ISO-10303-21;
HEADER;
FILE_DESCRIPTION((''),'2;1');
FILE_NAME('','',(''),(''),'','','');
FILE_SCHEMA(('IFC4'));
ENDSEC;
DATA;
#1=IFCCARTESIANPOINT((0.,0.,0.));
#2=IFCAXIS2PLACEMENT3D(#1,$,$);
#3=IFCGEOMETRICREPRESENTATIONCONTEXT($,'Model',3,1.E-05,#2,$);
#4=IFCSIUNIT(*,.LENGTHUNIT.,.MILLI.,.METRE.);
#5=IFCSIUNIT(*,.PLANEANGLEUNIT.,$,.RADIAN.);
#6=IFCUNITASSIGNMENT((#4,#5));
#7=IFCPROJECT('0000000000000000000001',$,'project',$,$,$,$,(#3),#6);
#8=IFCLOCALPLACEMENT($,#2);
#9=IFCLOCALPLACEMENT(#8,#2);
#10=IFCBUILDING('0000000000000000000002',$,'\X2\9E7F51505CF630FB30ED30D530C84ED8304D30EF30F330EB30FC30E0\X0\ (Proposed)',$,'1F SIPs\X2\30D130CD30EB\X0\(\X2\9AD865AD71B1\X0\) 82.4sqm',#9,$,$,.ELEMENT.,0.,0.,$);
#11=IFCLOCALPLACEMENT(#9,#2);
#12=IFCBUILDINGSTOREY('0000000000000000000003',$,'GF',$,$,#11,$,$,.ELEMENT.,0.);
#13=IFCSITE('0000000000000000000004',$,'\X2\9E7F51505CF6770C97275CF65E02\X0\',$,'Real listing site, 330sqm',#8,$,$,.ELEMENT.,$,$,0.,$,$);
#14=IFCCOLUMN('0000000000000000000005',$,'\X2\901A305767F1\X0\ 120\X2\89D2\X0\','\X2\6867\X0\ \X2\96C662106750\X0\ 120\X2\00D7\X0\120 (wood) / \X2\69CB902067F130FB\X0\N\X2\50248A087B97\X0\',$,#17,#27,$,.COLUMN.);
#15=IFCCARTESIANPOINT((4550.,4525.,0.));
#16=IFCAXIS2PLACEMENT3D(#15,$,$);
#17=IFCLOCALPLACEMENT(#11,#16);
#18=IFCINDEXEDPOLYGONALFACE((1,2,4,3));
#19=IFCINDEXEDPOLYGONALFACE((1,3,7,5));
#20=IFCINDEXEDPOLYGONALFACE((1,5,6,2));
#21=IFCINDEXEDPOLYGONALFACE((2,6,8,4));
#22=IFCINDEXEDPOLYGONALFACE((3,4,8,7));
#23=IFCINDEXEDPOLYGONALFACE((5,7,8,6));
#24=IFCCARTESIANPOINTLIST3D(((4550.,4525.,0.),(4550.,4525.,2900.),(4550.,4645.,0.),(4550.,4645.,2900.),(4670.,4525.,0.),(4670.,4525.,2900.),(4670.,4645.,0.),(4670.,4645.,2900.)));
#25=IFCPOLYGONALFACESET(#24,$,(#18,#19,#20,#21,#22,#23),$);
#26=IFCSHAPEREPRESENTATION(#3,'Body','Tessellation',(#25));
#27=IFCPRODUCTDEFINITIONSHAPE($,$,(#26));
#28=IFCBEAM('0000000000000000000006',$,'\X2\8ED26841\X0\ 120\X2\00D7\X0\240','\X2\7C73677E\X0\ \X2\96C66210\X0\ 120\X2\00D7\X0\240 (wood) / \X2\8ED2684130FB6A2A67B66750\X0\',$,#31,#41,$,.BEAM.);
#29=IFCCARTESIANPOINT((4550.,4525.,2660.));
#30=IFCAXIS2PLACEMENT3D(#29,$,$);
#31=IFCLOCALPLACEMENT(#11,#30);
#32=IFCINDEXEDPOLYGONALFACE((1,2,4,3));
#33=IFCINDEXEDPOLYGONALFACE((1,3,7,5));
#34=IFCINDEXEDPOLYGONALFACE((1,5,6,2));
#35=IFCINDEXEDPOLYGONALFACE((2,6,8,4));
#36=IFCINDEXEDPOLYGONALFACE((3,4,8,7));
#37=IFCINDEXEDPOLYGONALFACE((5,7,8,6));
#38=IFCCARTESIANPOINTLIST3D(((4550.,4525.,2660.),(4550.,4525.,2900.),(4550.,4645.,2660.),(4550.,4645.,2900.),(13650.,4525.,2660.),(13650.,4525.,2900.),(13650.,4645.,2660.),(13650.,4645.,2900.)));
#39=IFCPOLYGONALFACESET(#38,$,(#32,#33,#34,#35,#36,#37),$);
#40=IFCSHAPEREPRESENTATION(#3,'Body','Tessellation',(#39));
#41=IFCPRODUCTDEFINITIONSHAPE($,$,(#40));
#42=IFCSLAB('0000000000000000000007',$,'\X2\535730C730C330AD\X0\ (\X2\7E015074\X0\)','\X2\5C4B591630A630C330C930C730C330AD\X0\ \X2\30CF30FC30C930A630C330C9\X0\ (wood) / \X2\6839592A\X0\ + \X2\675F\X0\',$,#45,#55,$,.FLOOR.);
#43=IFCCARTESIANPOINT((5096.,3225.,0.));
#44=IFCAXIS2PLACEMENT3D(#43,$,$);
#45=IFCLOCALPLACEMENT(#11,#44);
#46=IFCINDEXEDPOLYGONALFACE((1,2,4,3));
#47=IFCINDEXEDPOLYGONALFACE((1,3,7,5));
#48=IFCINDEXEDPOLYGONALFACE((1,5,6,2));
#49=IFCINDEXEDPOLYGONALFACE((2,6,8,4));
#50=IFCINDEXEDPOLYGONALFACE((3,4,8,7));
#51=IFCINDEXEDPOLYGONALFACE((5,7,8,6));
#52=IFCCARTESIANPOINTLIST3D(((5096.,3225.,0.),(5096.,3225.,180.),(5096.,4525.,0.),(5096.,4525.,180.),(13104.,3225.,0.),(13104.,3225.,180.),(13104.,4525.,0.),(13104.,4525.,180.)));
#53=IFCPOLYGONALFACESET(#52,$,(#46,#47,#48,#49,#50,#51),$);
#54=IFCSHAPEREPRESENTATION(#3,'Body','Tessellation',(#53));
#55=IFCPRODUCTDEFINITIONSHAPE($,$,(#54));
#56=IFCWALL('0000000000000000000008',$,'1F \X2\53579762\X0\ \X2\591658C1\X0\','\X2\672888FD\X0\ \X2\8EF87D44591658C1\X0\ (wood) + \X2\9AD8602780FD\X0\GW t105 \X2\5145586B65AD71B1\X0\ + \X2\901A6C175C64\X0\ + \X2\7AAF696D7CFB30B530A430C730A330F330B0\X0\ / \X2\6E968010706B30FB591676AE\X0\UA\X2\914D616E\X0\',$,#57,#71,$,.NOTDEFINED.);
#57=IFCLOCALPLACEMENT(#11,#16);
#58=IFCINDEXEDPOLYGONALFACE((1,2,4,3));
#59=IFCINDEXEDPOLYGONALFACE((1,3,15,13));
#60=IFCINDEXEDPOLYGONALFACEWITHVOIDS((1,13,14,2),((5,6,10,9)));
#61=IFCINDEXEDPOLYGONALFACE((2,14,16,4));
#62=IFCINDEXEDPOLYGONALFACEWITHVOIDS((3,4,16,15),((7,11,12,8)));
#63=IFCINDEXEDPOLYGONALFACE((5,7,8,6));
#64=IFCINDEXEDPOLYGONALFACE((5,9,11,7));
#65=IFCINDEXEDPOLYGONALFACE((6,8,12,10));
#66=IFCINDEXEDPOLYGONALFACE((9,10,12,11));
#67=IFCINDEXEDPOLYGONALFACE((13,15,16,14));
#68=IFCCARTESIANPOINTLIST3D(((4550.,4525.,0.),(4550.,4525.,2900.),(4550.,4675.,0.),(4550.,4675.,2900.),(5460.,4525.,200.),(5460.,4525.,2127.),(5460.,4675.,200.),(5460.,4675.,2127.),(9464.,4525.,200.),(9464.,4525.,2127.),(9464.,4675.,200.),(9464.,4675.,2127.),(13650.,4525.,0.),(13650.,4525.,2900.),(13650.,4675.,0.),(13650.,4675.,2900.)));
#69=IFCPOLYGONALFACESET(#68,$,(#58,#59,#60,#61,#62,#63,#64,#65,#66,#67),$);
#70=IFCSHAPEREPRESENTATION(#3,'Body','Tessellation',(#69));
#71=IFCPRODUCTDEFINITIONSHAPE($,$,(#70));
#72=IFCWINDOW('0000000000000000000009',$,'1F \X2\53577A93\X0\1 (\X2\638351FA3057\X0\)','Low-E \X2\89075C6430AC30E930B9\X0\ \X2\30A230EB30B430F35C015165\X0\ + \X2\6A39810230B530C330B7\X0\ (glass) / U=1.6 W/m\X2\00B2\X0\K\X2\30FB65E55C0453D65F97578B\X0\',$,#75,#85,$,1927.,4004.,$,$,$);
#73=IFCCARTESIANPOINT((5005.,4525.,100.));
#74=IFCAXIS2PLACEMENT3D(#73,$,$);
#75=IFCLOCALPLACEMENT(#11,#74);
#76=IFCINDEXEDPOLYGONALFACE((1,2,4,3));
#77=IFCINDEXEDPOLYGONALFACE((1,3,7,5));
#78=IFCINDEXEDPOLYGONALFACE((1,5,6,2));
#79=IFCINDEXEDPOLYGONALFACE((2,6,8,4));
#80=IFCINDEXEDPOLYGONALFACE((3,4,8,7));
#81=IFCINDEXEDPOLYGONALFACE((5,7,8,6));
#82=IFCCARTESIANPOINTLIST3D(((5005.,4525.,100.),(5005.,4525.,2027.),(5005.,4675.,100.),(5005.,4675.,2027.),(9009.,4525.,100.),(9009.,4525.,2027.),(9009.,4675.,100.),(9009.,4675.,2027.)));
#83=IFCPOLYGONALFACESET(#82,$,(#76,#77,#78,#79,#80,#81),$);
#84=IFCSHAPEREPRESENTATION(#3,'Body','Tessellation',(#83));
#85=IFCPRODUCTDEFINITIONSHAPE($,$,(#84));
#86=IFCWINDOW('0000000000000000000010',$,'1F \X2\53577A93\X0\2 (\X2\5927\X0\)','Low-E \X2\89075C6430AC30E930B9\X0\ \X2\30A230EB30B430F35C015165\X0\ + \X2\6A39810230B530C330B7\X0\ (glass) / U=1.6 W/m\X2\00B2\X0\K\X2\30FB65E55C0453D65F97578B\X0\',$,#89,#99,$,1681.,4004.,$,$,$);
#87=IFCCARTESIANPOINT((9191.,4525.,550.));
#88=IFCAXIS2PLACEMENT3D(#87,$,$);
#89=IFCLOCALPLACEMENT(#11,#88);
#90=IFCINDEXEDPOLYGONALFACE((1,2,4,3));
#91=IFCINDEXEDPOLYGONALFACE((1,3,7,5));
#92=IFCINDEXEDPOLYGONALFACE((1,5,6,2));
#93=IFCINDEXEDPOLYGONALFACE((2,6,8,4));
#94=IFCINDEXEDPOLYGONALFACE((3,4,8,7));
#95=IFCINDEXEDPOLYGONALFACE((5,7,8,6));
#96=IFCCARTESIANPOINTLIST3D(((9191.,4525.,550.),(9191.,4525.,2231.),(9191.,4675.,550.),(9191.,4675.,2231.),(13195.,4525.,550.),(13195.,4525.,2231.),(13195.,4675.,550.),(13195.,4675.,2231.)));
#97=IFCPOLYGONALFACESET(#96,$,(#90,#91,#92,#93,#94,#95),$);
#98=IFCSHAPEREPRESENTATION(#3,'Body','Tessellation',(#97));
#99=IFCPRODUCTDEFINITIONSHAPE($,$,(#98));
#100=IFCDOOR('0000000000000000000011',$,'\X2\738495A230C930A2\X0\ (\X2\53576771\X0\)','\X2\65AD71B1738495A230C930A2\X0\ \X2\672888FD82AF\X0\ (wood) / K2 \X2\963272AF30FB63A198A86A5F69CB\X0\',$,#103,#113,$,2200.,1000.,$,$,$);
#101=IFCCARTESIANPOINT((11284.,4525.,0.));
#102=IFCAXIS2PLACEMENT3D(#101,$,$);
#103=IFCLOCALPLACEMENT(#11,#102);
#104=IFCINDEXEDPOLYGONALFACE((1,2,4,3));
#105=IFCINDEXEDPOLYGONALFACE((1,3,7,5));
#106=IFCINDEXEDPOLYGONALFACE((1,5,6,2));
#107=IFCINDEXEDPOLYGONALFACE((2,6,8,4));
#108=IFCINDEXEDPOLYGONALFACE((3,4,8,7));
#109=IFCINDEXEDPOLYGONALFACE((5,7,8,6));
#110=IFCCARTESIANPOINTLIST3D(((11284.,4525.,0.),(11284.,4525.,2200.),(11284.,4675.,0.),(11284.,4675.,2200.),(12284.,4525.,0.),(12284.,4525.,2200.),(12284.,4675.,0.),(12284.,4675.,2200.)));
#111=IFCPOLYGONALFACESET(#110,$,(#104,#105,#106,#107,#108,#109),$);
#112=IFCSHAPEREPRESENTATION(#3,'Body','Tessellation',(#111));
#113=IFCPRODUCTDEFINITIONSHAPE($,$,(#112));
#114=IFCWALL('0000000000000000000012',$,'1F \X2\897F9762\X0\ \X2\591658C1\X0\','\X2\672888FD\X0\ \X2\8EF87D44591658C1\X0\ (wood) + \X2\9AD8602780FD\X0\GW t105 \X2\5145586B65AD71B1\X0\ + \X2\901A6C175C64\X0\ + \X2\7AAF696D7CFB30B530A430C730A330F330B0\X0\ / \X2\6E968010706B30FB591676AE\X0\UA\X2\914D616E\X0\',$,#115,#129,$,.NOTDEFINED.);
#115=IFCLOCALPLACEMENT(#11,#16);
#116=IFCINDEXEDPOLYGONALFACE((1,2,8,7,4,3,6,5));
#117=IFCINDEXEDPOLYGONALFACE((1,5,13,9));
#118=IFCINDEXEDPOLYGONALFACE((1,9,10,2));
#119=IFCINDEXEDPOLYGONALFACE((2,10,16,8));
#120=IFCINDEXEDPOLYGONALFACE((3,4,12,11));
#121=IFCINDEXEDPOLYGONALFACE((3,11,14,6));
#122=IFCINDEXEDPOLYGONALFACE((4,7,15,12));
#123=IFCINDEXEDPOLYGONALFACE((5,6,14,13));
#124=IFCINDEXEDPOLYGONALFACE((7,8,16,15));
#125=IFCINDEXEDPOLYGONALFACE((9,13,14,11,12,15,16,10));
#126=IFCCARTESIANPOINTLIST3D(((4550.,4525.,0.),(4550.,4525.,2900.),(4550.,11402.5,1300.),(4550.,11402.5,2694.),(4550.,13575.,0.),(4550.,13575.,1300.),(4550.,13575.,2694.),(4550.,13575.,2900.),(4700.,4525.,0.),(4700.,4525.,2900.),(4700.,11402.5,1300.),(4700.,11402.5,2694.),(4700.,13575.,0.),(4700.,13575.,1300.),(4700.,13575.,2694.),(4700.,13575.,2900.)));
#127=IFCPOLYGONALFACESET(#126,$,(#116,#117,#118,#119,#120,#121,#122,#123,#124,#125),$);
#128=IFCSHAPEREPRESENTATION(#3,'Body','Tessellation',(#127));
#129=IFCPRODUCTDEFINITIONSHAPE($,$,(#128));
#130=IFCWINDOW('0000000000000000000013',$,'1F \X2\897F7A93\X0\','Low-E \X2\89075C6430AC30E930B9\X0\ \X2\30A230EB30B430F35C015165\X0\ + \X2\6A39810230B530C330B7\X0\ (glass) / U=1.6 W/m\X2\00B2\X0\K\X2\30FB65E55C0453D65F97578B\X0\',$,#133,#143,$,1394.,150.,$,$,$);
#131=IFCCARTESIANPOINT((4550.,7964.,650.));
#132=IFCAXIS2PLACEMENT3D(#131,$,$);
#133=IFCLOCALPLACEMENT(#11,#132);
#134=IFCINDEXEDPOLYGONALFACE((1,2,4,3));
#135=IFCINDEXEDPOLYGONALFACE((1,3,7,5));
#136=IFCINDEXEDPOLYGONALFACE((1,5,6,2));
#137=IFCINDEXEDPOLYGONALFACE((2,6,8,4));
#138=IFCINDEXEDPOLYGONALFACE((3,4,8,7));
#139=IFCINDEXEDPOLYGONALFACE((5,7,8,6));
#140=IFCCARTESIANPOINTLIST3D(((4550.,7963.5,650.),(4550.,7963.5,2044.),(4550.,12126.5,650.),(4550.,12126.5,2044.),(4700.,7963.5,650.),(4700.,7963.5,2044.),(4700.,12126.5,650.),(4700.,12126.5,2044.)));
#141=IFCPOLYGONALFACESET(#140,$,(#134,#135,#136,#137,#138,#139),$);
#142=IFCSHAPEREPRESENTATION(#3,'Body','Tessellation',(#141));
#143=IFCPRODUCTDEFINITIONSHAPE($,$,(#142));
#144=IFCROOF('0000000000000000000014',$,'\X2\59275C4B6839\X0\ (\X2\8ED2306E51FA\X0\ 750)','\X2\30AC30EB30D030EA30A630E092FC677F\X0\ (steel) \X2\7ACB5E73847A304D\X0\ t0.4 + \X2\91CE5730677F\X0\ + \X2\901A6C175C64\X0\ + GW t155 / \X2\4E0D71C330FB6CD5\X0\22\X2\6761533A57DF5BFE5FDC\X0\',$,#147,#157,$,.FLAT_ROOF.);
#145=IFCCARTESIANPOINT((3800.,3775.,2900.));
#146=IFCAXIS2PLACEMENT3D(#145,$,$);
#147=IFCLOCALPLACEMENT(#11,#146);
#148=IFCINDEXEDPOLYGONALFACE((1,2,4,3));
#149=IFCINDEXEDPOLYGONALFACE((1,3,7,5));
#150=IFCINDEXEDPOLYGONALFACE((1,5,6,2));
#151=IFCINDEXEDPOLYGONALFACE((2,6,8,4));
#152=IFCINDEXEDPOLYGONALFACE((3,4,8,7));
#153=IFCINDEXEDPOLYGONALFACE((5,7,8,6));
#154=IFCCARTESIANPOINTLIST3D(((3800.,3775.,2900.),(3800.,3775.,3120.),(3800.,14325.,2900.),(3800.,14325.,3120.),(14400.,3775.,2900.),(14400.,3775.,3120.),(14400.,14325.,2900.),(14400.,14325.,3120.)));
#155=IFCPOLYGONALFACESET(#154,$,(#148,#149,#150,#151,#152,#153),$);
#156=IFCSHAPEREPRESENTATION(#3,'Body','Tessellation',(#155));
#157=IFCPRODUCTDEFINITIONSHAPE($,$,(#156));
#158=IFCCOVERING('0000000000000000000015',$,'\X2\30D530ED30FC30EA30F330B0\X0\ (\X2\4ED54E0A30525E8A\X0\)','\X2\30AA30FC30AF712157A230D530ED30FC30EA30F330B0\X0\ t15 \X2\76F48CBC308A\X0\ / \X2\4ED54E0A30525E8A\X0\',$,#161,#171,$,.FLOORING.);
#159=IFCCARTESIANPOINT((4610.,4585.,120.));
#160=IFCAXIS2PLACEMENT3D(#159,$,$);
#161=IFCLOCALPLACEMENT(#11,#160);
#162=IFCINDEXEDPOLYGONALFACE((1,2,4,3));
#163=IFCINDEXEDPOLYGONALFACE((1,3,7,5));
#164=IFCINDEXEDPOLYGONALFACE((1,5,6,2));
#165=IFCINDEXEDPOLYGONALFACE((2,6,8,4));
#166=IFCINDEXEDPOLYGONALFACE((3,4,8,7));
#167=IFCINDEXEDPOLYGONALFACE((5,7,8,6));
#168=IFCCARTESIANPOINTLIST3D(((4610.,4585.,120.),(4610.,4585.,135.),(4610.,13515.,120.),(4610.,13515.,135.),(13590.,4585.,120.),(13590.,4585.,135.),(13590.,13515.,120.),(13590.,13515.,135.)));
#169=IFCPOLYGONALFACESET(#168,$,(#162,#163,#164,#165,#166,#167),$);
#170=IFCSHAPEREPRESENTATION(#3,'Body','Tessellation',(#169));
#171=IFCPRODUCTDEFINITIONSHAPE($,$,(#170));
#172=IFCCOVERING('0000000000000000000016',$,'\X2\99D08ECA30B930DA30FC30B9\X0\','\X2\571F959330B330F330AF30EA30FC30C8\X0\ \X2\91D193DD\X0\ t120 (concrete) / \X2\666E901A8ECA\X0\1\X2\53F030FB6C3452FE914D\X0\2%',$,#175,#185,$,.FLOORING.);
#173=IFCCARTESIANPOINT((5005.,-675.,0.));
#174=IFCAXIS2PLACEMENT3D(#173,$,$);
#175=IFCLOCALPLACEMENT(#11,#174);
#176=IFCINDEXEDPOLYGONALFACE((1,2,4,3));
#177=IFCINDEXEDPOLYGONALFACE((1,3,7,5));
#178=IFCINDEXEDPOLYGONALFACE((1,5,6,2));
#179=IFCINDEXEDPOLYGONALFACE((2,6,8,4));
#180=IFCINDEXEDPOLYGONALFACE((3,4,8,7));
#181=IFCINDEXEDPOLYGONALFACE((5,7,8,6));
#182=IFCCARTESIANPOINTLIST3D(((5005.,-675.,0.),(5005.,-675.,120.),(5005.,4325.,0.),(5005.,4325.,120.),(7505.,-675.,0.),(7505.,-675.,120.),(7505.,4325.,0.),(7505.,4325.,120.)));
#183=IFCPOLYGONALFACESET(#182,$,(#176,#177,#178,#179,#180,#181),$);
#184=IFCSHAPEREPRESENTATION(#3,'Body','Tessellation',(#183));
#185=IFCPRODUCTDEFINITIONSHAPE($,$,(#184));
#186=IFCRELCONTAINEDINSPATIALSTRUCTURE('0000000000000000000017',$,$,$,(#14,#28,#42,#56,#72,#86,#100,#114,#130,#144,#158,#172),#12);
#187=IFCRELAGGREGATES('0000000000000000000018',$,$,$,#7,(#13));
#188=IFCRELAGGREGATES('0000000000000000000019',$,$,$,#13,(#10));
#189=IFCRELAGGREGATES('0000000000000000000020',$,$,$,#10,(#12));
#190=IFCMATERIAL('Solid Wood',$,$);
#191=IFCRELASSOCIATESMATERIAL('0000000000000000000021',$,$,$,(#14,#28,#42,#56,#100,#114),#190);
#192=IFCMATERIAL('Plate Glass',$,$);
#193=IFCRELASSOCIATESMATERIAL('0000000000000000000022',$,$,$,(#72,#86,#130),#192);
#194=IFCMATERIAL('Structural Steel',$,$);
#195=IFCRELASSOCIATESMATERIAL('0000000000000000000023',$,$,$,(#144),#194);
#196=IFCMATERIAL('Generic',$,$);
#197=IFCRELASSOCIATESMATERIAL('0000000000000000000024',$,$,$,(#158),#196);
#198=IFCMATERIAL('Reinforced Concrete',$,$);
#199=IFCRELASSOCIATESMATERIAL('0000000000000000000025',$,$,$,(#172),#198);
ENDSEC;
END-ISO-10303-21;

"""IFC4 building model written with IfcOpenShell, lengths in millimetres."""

from ifc_helpers import new_model, si_unit, frame, frame_2d, origin, place, context, project, spatial, rectangle, extrude, material, element, fill, save


model = new_model("IFC4")

# Units and contexts
model_context = context("Model", 3, precision=1e-05, world=origin())
ifc_project = project(units=[si_unit("LENGTHUNIT", "METRE", prefix="MILLI"), si_unit("PLANEANGLEUNIT", "RADIAN")], contexts=[model_context])

# Site, building, storey
site_placement = place(None, origin())
site = spatial("IfcSite", under=ifc_project, at=site_placement, Name="鹿児島県霧島市", ObjectType="Real listing site, 330sqm", CompositionType="ELEMENT", RefElevation=0.0)
building_placement = place(site_placement, origin())
building = spatial("IfcBuilding", under=site, at=building_placement, Name="鹿児島・ロフト付きワンルーム (Proposed)", ObjectType="1F SIPsパネル(高断熱) 82.4sqm", CompositionType="ELEMENT", ElevationOfRefHeight=0.0, ElevationOfTerrain=0.0)
storey_placement = place(building_placement, origin())
storey = spatial("IfcBuildingStorey", under=building, at=storey_placement, Name="GF", CompositionType="ELEMENT", Elevation=0.0)

# Column
ifc_material_1 = material(Name="Solid Wood")
column_1_placement = place(storey_placement, frame((4550.0, 4525.0, 0.0)))
element("IfcColumn", 1, at=column_1_placement, inside=storey, material=ifc_material_1, Name="通し柱 120角", Description="桧 集成材 120×120 (wood) / 構造柱・N値計算", PredefinedType="COLUMN", context=model_context, shape_type="SweptSolid", body=[
    extrude(rectangle(XDim=120.0, YDim=120.0, at=frame_2d((60.0, 60.0))), frame((4550.0, 4525.0, 0.0)), (0.0, 0.0, 1.0), 2900.0),
])

# Beam
beam_1_placement = place(storey_placement, frame((4550.0, 4525.0, 2660.0)))
element("IfcBeam", 2, at=beam_1_placement, inside=storey, material=ifc_material_1, Name="軒桁 120×240", Description="米松 集成 120×240 (wood) / 軒桁・横架材", PredefinedType="BEAM", context=model_context, shape_type="SweptSolid", body=[
    extrude(rectangle(XDim=9100.0, YDim=120.0, at=frame_2d((4550.0, 60.0))), frame((4550.0, 4525.0, 2660.0)), (0.0, 0.0, 1.0), 240.0),
])

# Slab
ifc_material_2 = material(Name="Reinforced Concrete")
slab_1_placement = place(storey_placement, frame((5096.0, 3225.0, 0.0)))
element("IfcSlab", 3, at=slab_1_placement, inside=storey, material=ifc_material_1, Name="南デッキ (縁側)", Description="屋外ウッドデッキ ハードウッド (wood) / 根太 + 束", PredefinedType="FLOOR", context=model_context, shape_type="SweptSolid", body=[
    extrude(rectangle(XDim=8008.0, YDim=1300.0, at=frame_2d((4004.0, 650.0))), frame((5096.0, 3225.0, 0.0)), (0.0, 0.0, 1.0), 180.0),
])

# Wall, openings, windows, door
wall_1_placement = place(storey_placement, frame((4550.0, 4525.0, 0.0)))
wall_1 = element("IfcWall", 4, at=wall_1_placement, inside=storey, material=ifc_material_1, Name="1F 南面 外壁", Description="木製 軸組外壁 (wood) + 高性能GW t105 充填断熱 + 通気層 + 窯業系サイディング / 準耐火・外皮UA配慮", PredefinedType="NOTDEFINED", context=model_context, shape_type="SweptSolid", body=[
    extrude(rectangle(XDim=9100.0, YDim=150.0, at=frame_2d((4550.0, 75.0))), frame((4550.0, 4525.0, 0.0)), (0.0, 0.0, 1.0), 2900.0),
])
opening_1_placement = place(storey_placement, frame((5005.0, 4525.0, 100.0)))
opening_1 = element("IfcOpeningElement", 5, at=opening_1_placement, cuts=wall_1, PredefinedType="NOTDEFINED", context=model_context, shape_type="SweptSolid", body=[
    extrude(rectangle(XDim=4004.0, YDim=150.0, at=frame_2d((2002.0, 75.0))), frame((5005.0, 4525.0, 100.0)), (0.0, 0.0, 1.0), 1927.0),
])
opening_2_placement = place(storey_placement, frame((9191.0, 4525.0, 550.0)))
opening_2 = element("IfcOpeningElement", 6, at=opening_2_placement, cuts=wall_1, PredefinedType="NOTDEFINED", context=model_context, shape_type="SweptSolid", body=[
    extrude(rectangle(XDim=4004.0, YDim=150.0, at=frame_2d((2002.0, 75.0))), frame((9191.0, 4525.0, 550.0)), (0.0, 0.0, 1.0), 1681.0),
])
opening_3_placement = place(storey_placement, frame((11284.0, 4525.0, 0.0)))
opening_3 = element("IfcOpeningElement", 7, at=opening_3_placement, cuts=wall_1, PredefinedType="NOTDEFINED", context=model_context, shape_type="SweptSolid", body=[
    extrude(rectangle(XDim=1000.0, YDim=150.0, at=frame_2d((500.0, 75.0))), frame((11284.0, 4525.0, 0.0)), (0.0, 0.0, 1.0), 2200.0),
])
ifc_material_3 = material(Name="Plate Glass")
window_1_placement = place(storey_placement, frame((5005.0, 4525.0, 100.0)))
window_1 = element("IfcWindow", 8, at=window_1_placement, inside=storey, material=ifc_material_3, Name="1F 南窓1 (掃出し)", Description="Low-E 複層ガラス アルゴン封入 + 樹脂サッシ (glass) / U=1.6 W/m²K・日射取得型", OverallHeight=1927.0, OverallWidth=4004.0, context=model_context, shape_type="SweptSolid", body=[
    extrude(rectangle(XDim=4004.0, YDim=150.0, at=frame_2d((2002.0, 75.0))), frame((5005.0, 4525.0, 100.0)), (0.0, 0.0, 1.0), 1927.0),
])
fill(opening_1, window_1)
window_2_placement = place(storey_placement, frame((9191.0, 4525.0, 550.0)))
window_2 = element("IfcWindow", 9, at=window_2_placement, inside=storey, material=ifc_material_3, Name="1F 南窓2 (大)", Description="Low-E 複層ガラス アルゴン封入 + 樹脂サッシ (glass) / U=1.6 W/m²K・日射取得型", OverallHeight=1681.0, OverallWidth=4004.0, context=model_context, shape_type="SweptSolid", body=[
    extrude(rectangle(XDim=4004.0, YDim=150.0, at=frame_2d((2002.0, 75.0))), frame((9191.0, 4525.0, 550.0)), (0.0, 0.0, 1.0), 1681.0),
])
fill(opening_2, window_2)
door_placement = place(storey_placement, frame((11284.0, 4525.0, 0.0)))
door = element("IfcDoor", 10, at=door_placement, inside=storey, material=ifc_material_1, Name="玄関ドア (南東)", Description="断熱玄関ドア 木製芯 (wood) / K2 防犯・採風機構", OverallHeight=2200.0, OverallWidth=1000.0, context=model_context, shape_type="SweptSolid", body=[
    extrude(rectangle(XDim=1000.0, YDim=150.0, at=frame_2d((500.0, 75.0))), frame((11284.0, 4525.0, 0.0)), (0.0, 0.0, 1.0), 2200.0),
])
fill(opening_3, door)

# Wall, opening, window
wall_2_placement = place(storey_placement, frame((4550.0, 4525.0, 0.0)))
wall_2 = element("IfcWall", 11, at=wall_2_placement, inside=storey, material=ifc_material_1, Name="1F 西面 外壁", Description="木製 軸組外壁 (wood) + 高性能GW t105 充填断熱 + 通気層 + 窯業系サイディング / 準耐火・外皮UA配慮", PredefinedType="NOTDEFINED", context=model_context, shape_type="SweptSolid", body=[
    extrude(rectangle(XDim=150.0, YDim=9050.0, at=frame_2d((75.0, 4525.0))), frame((4550.0, 4525.0, 0.0)), (0.0, 0.0, 1.0), 2900.0),
])
opening_4_placement = place(storey_placement, frame((4550.0, 7964.0, 650.0)))
opening_4 = element("IfcOpeningElement", 12, at=opening_4_placement, cuts=wall_2, PredefinedType="NOTDEFINED", context=model_context, shape_type="SweptSolid", body=[
    extrude(rectangle(XDim=150.0, YDim=4163.0, at=frame_2d((75.0, 2081.0))), frame((4550.0, 7964.0, 650.0)), (0.0, 0.0, 1.0), 1394.0),
])
window_3_placement = place(storey_placement, frame((4550.0, 7964.0, 650.0)))
window_3 = element("IfcWindow", 13, at=window_3_placement, inside=storey, material=ifc_material_3, Name="1F 西窓", Description="Low-E 複層ガラス アルゴン封入 + 樹脂サッシ (glass) / U=1.6 W/m²K・日射取得型", OverallHeight=1394.0, OverallWidth=150.0, context=model_context, shape_type="SweptSolid", body=[
    extrude(rectangle(XDim=150.0, YDim=4163.0, at=frame_2d((75.0, 2081.0))), frame((4550.0, 7964.0, 650.0)), (0.0, 0.0, 1.0), 1394.0),
])
fill(opening_4, window_3)

# Roof
ifc_material_4 = material(Name="Structural Steel")
roof_placement = place(storey_placement, frame((3800.0, 3775.0, 2900.0)))
element("IfcRoof", 14, at=roof_placement, inside=storey, material=ifc_material_4, Name="大屋根 (軒の出 750)", Description="ガルバリウム鋼板 (steel) 立平葺き t0.4 + 野地板 + 通気層 + GW t155 / 不燃・法22条区域対応", PredefinedType="FLAT_ROOF", context=model_context, shape_type="SweptSolid", body=[
    extrude(rectangle(XDim=10600.0, YDim=10550.0, at=frame_2d((5300.0, 5275.0))), frame((3800.0, 3775.0, 2900.0)), (0.0, 0.0, 1.0), 220.0),
])

# Coverings
ifc_material_5 = material(Name="Generic")
covering_1_placement = place(storey_placement, frame((4610.0, 4585.0, 120.0)))
element("IfcCovering", 15, at=covering_1_placement, inside=storey, material=ifc_material_5, Name="フローリング (仕上げ床)", Description="オーク無垢フローリング t15 直貼り / 仕上げ床", PredefinedType="FLOORING", context=model_context, shape_type="SweptSolid", body=[
    extrude(rectangle(XDim=8980.0, YDim=8930.0, at=frame_2d((4490.0, 4465.0))), frame((4610.0, 4585.0, 120.0)), (0.0, 0.0, 1.0), 15.0),
])
covering_2_placement = place(storey_placement, frame((5005.0, -675.0, 0.0)))
element("IfcCovering", 16, at=covering_2_placement, inside=storey, material=ifc_material_2, Name="駐車スペース", Description="土間コンクリート 金鏝 t120 (concrete) / 普通車1台・水勾配2%", PredefinedType="FLOORING", context=model_context, shape_type="SweptSolid", body=[
    extrude(rectangle(XDim=2500.0, YDim=5000.0, at=frame_2d((1250.0, 2500.0))), frame((5005.0, -675.0, 0.0)), (0.0, 0.0, 1.0), 120.0),
])

save(model, "model.ifc")
